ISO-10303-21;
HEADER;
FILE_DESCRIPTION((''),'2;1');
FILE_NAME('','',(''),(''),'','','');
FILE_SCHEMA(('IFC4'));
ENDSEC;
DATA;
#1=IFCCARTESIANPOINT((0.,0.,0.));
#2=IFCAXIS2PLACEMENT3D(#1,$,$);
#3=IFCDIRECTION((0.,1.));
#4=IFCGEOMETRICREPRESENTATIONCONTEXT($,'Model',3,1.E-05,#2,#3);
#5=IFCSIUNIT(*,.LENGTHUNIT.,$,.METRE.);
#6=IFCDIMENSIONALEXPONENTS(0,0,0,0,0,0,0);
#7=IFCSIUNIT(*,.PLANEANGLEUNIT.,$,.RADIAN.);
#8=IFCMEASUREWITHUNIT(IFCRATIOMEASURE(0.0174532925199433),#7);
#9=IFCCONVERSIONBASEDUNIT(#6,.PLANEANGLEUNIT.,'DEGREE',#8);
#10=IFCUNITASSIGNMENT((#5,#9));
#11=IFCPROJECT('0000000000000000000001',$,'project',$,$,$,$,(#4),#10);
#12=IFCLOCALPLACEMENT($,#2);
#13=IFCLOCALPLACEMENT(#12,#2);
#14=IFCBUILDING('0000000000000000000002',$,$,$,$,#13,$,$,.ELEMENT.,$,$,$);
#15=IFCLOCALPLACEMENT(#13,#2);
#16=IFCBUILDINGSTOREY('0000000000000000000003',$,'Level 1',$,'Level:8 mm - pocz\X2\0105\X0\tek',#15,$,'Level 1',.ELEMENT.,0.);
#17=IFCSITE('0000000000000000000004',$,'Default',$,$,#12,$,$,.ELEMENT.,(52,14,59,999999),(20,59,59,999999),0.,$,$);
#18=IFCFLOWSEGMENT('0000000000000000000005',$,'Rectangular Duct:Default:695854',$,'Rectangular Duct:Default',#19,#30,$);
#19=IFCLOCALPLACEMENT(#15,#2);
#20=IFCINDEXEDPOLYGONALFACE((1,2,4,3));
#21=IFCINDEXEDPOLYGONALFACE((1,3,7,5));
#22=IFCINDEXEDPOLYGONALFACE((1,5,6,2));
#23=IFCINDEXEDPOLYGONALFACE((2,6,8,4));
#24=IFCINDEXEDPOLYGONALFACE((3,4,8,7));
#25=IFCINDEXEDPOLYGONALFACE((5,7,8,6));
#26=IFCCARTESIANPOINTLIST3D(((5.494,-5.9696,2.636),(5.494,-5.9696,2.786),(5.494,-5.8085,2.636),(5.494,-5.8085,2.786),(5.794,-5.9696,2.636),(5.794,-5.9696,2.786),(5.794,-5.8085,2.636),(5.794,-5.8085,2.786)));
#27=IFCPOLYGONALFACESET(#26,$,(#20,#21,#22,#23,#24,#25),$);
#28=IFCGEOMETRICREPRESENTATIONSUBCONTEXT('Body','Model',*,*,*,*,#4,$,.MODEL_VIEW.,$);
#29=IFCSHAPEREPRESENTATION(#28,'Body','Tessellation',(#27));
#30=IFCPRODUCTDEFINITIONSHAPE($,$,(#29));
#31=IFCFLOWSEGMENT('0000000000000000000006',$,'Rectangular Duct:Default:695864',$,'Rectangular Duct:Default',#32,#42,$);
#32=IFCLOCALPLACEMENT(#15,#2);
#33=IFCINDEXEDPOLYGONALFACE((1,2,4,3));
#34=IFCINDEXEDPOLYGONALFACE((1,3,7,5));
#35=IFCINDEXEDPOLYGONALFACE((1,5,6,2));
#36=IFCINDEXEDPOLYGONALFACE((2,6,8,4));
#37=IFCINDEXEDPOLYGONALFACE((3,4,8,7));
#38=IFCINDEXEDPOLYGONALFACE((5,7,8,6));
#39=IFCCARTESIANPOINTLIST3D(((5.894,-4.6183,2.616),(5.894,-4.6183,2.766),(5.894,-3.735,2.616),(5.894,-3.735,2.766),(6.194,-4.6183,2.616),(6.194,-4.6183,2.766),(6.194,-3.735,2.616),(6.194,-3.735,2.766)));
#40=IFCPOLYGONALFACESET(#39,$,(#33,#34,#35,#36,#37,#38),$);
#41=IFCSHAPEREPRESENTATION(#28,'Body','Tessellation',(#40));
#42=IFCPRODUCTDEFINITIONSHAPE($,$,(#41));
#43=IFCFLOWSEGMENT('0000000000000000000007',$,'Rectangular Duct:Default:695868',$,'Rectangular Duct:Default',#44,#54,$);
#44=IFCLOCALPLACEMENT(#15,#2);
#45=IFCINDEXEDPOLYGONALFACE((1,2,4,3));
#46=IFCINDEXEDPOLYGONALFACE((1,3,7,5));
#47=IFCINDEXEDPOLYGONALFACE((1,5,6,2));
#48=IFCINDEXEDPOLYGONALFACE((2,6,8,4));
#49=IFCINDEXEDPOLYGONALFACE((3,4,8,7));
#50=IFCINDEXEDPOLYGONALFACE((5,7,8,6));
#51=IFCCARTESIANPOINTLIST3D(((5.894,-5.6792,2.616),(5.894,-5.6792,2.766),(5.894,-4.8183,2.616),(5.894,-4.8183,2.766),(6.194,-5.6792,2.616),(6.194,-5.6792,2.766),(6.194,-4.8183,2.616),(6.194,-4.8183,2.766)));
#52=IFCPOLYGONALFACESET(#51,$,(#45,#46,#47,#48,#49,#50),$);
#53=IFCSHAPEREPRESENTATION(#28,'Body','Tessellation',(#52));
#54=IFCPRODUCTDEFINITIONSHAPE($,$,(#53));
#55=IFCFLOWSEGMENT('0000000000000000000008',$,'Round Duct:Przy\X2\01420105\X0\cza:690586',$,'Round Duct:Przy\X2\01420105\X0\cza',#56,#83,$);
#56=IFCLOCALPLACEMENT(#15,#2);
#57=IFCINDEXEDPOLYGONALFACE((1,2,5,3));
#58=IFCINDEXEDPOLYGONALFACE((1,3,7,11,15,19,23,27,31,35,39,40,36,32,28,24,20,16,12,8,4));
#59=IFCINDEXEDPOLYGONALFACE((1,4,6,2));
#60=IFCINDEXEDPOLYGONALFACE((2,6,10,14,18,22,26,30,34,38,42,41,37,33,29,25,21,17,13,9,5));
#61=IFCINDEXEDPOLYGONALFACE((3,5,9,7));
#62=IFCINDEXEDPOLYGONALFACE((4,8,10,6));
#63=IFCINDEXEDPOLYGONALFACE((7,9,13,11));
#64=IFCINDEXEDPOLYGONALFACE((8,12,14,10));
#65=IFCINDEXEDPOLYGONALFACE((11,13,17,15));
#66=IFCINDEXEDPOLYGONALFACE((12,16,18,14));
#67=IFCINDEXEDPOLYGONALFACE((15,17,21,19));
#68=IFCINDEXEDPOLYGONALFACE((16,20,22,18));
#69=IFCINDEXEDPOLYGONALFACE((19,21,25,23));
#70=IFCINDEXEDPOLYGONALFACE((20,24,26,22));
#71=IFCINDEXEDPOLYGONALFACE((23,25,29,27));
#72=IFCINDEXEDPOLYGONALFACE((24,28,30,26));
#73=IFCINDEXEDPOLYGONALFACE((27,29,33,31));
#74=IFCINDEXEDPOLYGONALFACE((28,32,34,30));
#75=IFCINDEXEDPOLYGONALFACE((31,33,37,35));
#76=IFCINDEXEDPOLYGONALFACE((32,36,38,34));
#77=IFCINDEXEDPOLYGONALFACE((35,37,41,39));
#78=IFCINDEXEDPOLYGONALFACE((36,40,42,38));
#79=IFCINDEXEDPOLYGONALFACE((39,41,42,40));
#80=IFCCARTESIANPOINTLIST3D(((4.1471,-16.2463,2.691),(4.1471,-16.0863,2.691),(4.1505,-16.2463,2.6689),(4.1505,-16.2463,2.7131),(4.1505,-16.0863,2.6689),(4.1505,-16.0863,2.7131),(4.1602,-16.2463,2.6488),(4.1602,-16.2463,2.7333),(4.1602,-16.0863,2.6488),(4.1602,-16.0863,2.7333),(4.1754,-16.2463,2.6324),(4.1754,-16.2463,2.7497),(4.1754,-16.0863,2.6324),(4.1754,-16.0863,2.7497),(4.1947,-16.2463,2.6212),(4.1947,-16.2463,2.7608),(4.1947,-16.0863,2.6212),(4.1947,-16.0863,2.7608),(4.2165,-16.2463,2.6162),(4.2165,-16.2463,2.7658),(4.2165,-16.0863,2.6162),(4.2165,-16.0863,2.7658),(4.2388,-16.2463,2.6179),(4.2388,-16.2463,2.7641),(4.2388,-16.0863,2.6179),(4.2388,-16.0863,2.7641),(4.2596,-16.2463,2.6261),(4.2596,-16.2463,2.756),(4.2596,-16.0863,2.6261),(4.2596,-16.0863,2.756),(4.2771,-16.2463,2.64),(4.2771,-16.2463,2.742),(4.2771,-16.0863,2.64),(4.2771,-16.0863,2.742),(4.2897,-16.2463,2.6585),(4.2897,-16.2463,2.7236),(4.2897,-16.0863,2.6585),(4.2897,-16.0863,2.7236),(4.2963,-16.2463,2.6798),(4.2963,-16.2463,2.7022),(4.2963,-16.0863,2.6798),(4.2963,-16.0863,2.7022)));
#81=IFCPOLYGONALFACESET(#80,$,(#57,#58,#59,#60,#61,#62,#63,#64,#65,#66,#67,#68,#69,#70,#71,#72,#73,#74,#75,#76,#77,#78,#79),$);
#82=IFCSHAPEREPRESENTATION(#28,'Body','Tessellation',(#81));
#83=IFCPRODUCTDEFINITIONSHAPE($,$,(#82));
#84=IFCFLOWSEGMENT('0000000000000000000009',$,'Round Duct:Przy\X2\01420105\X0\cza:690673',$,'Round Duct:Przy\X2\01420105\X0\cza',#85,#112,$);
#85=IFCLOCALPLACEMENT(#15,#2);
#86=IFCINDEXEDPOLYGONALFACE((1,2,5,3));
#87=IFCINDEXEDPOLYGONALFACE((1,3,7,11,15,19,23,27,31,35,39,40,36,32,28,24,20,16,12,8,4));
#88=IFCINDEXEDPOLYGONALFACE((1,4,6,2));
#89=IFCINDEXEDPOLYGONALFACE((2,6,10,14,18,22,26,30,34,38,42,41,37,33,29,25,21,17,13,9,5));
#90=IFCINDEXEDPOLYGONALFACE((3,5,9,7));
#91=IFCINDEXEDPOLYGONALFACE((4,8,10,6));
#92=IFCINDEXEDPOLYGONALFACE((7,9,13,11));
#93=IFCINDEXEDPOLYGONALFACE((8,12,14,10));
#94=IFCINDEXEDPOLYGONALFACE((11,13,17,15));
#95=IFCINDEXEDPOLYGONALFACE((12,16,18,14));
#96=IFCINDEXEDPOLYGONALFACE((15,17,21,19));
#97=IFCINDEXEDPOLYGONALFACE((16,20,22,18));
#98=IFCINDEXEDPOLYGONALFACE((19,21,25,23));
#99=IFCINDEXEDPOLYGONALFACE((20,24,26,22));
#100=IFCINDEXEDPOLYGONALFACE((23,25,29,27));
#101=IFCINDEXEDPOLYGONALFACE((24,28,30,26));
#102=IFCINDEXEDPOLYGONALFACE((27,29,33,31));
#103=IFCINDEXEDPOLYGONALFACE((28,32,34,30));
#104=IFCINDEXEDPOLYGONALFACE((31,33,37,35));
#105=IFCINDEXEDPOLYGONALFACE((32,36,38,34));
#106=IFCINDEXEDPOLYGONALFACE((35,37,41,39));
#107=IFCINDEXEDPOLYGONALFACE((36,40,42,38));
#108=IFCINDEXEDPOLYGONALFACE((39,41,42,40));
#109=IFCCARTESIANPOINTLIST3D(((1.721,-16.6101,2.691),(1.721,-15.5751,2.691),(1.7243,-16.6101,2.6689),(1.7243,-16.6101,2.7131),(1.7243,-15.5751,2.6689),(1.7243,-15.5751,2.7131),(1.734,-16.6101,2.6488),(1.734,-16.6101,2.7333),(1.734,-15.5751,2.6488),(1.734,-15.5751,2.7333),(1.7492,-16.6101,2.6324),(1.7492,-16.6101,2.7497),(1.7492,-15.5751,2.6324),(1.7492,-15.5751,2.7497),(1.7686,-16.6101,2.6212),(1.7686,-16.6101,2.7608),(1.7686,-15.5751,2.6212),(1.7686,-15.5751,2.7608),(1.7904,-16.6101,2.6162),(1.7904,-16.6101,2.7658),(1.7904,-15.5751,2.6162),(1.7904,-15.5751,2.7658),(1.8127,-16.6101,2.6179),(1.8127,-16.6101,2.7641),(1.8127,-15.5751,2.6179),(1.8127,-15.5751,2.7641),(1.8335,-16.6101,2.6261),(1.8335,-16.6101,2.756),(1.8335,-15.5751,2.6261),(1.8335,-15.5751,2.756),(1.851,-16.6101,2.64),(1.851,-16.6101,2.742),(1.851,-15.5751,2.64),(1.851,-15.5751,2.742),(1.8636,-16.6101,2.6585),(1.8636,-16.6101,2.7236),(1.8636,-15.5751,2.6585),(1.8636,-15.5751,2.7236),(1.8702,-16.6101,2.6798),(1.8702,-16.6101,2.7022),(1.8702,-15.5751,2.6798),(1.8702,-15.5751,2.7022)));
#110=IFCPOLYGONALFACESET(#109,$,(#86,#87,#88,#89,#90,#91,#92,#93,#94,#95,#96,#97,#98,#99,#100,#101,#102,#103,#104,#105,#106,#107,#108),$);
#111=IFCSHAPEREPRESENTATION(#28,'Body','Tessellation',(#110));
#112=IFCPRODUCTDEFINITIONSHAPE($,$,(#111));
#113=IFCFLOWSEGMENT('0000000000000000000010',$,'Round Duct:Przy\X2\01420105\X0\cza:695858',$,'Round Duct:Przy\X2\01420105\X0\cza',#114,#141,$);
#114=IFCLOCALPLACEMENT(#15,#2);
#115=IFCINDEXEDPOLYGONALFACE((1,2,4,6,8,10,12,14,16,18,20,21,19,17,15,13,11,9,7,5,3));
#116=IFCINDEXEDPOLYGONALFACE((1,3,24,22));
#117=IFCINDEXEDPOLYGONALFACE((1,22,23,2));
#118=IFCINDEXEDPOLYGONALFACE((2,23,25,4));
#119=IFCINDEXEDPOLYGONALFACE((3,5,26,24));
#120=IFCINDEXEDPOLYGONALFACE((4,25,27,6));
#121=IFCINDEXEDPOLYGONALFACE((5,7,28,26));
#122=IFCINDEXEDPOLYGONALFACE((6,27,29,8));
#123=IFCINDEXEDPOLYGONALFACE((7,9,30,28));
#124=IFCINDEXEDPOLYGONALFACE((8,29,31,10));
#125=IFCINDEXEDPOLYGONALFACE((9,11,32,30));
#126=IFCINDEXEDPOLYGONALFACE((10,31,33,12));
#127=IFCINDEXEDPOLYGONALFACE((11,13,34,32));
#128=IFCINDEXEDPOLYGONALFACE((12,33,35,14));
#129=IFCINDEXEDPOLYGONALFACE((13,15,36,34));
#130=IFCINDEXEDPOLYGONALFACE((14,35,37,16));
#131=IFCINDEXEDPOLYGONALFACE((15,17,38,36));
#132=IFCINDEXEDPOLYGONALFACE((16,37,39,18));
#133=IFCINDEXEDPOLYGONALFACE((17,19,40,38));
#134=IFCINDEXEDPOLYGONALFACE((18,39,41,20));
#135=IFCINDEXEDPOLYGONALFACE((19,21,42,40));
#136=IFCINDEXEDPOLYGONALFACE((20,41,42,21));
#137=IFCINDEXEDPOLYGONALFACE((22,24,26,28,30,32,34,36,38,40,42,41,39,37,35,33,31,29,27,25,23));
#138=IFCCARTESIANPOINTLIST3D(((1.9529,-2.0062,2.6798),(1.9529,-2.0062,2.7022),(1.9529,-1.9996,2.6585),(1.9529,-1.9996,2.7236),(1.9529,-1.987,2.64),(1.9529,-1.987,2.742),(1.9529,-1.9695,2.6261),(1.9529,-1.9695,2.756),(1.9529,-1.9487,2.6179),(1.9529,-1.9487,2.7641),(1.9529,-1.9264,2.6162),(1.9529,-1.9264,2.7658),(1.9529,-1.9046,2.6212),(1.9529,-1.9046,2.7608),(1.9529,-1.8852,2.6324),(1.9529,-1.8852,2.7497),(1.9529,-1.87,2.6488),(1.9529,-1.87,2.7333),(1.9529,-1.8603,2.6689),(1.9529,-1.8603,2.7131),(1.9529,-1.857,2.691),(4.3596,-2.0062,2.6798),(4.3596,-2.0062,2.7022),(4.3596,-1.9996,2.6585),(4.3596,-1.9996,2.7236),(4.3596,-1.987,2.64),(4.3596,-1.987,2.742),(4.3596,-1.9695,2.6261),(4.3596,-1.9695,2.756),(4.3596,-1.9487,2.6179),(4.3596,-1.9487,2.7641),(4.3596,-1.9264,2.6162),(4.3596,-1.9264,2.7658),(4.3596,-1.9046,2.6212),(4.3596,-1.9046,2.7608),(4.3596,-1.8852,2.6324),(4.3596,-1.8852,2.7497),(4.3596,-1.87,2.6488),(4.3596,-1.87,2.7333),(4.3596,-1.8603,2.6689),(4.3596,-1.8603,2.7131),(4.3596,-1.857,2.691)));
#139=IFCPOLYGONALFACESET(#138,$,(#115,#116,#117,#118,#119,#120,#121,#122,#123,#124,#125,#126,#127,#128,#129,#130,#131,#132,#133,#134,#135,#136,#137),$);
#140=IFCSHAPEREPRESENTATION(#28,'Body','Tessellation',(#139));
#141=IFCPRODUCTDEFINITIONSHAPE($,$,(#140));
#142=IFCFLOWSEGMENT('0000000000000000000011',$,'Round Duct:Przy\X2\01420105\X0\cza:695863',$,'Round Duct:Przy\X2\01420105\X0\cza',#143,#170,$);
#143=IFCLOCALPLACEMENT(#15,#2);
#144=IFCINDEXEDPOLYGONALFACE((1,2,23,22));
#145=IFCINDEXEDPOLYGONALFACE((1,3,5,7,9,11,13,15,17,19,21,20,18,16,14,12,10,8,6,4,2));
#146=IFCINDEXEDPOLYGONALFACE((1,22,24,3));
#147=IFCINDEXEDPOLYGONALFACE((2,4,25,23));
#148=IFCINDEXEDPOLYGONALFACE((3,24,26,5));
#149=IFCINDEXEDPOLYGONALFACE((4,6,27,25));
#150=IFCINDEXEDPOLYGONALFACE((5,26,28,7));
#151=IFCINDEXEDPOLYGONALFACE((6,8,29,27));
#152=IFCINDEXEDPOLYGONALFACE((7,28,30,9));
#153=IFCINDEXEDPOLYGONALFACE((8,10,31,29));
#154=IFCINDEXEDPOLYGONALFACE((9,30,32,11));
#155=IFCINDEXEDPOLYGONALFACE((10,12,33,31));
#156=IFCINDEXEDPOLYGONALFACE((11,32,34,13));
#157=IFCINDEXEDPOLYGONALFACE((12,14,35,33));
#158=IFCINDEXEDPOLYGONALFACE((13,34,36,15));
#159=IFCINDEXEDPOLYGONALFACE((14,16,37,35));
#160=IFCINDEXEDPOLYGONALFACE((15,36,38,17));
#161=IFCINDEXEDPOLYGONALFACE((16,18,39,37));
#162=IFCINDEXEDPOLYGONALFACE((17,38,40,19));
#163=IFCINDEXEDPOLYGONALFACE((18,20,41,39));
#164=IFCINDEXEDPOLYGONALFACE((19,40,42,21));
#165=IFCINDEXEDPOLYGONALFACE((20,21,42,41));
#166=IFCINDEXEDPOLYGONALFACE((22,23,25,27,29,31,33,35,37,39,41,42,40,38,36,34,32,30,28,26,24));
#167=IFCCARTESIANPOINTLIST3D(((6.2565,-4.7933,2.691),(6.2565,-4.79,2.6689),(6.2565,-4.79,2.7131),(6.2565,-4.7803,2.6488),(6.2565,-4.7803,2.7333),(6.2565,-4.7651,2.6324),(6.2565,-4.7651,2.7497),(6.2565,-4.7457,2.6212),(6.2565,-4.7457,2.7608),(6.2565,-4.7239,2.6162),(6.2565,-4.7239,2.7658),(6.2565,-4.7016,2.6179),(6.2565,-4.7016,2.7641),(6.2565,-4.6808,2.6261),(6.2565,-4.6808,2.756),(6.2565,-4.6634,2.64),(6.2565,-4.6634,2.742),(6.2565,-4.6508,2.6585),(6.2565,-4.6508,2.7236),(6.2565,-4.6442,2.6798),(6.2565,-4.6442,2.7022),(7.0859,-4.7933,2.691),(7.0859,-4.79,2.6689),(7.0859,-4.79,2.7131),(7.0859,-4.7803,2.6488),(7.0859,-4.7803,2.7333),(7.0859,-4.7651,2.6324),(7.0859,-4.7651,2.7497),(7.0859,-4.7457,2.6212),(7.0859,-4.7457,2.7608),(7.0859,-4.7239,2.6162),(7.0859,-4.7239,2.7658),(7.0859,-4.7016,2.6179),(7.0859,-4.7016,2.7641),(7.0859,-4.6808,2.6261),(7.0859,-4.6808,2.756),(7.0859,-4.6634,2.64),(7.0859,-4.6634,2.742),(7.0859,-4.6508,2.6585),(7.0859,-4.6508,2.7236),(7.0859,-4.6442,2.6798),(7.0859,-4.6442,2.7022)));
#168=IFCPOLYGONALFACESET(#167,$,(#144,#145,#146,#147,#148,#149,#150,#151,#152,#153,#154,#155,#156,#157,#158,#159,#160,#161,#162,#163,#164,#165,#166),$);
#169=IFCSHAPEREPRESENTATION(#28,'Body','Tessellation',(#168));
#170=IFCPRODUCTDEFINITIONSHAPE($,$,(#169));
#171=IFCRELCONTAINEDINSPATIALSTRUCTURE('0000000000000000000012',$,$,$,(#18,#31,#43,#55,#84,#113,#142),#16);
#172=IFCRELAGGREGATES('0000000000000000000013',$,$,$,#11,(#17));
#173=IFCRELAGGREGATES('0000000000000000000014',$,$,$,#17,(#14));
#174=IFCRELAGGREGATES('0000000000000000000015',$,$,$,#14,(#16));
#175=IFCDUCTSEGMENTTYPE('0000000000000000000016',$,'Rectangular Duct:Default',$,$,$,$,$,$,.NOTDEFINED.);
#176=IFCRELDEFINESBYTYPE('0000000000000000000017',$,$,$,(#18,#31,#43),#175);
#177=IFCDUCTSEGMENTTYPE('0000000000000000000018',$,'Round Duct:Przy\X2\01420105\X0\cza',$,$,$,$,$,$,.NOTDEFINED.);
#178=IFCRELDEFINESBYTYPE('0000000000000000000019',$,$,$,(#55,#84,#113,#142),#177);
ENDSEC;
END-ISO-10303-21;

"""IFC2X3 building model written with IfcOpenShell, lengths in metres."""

from ifc_helpers import new_model, entity, si_unit, converted_unit, direction, frame, frame_2d, origin, place, context, subcontext, project, spatial, rectangle, circle, extrude, type_object, element, save


model = new_model("IFC2X3")

# Units and contexts
model_context = context("Model", 3, precision=1e-05, world=origin(), true_north=direction((0.0, 1.0)))
body_context = subcontext(model_context, "Body", "Model", "MODEL_VIEW")
ifc_project = project(units=[si_unit("LENGTHUNIT", "METRE"), converted_unit("PLANEANGLEUNIT", "DEGREE", entity("IfcRatioMeasure", 0.0174532925199433), si_unit("PLANEANGLEUNIT", "RADIAN"), dimensions=[0, 0, 0, 0, 0, 0, 0])], contexts=[model_context])

# Site, building, storey
site_placement = place(None, origin())
site = spatial("IfcSite", under=ifc_project, at=site_placement, Name="Default", CompositionType="ELEMENT", RefLatitude=(52, 14, 59, 999999), RefLongitude=(20, 59, 59, 999999), RefElevation=0.0)
building_placement = place(site_placement, origin())
building = spatial("IfcBuilding", under=site, at=building_placement, CompositionType="ELEMENT")
storey_placement = place(building_placement, origin())
storey = spatial("IfcBuildingStorey", under=building, at=storey_placement, Name="Level 1", ObjectType="Level:8 mm - początek", LongName="Level 1", CompositionType="ELEMENT", Elevation=0.0)

# Flow segments
duct_segment_type_1 = type_object("IfcDuctSegmentType", Name="Rectangular Duct:Default", PredefinedType="NOTDEFINED")
flow_segment_1_placement = place(storey_placement, origin())
element("IfcFlowSegment", 1, at=flow_segment_1_placement, inside=storey, type_object=duct_segment_type_1, Name="Rectangular Duct:Default:695854", ObjectType="Rectangular Duct:Default", context=body_context, shape_type="SweptSolid", body=[
    extrude(rectangle(XDim=0.1611, YDim=0.3, at=frame_2d((0.0, 0.0), x_axis=(1.0, 0.0))), frame((5.644, -5.889, 2.636), z_axis=(0.0, 0.0, 1.0), x_axis=(0.0, 1.0, 0.0)), (0.0, 0.0, 1.0), 0.15),
])
flow_segment_2_placement = place(storey_placement, origin())
element("IfcFlowSegment", 2, at=flow_segment_2_placement, inside=storey, type_object=duct_segment_type_1, Name="Rectangular Duct:Default:695864", ObjectType="Rectangular Duct:Default", context=body_context, shape_type="SweptSolid", body=[
    extrude(rectangle(XDim=0.8833, YDim=0.3, at=frame_2d((0.0, 0.0), x_axis=(1.0, 0.0))), frame((6.044, -4.1767, 2.616), z_axis=(0.0, 0.0, 1.0), x_axis=(0.0, 1.0, 0.0)), (0.0, 0.0, 1.0), 0.15),
])
flow_segment_3_placement = place(storey_placement, origin())
element("IfcFlowSegment", 3, at=flow_segment_3_placement, inside=storey, type_object=duct_segment_type_1, Name="Rectangular Duct:Default:695868", ObjectType="Rectangular Duct:Default", context=body_context, shape_type="SweptSolid", body=[
    extrude(rectangle(XDim=0.8609, YDim=0.3, at=frame_2d((0.0, 0.0), x_axis=(1.0, 0.0))), frame((6.044, -5.2488, 2.616), z_axis=(0.0, 0.0, 1.0), x_axis=(0.0, 1.0, 0.0)), (0.0, 0.0, 1.0), 0.15),
])
duct_segment_type_2 = type_object("IfcDuctSegmentType", Name="Round Duct:Przyłącza", PredefinedType="NOTDEFINED")
flow_segment_4_placement = place(storey_placement, origin())
element("IfcFlowSegment", 4, at=flow_segment_4_placement, inside=storey, type_object=duct_segment_type_2, Name="Round Duct:Przyłącza:690586", ObjectType="Round Duct:Przyłącza", context=body_context, shape_type="SweptSolid", body=[
    extrude(circle(Radius=0.075, at=frame_2d((0.0, 0.0), x_axis=(1.0, 0.0))), frame((4.2221, -16.2463, 2.691), z_axis=(0.0, 1.0, 0.0), x_axis=(-1.0, 0.0, 0.0)), (0.0, 0.0, 1.0), 0.16),
])
flow_segment_5_placement = place(storey_placement, origin())
element("IfcFlowSegment", 5, at=flow_segment_5_placement, inside=storey, type_object=duct_segment_type_2, Name="Round Duct:Przyłącza:690673", ObjectType="Round Duct:Przyłącza", context=body_context, shape_type="SweptSolid", body=[
    extrude(circle(Radius=0.075, at=frame_2d((0.0, 0.0), x_axis=(1.0, 0.0))), frame((1.796, -16.6101, 2.691), z_axis=(0.0, 1.0, 0.0), x_axis=(-1.0, 0.0, 0.0)), (0.0, 0.0, 1.0), 1.035),
])
flow_segment_6_placement = place(storey_placement, origin())
element("IfcFlowSegment", 6, at=flow_segment_6_placement, inside=storey, type_object=duct_segment_type_2, Name="Round Duct:Przyłącza:695858", ObjectType="Round Duct:Przyłącza", context=body_context, shape_type="SweptSolid", body=[
    extrude(circle(Radius=0.075, at=frame_2d((0.0, 0.0), x_axis=(1.0, 0.0))), frame((1.9529, -1.932, 2.691), z_axis=(1.0, 0.0, 0.0), x_axis=(0.0, 1.0, 0.0)), (0.0, 0.0, 1.0), 2.4067),
])
flow_segment_7_placement = place(storey_placement, origin())
element("IfcFlowSegment", 7, at=flow_segment_7_placement, inside=storey, type_object=duct_segment_type_2, Name="Round Duct:Przyłącza:695863", ObjectType="Round Duct:Przyłącza", context=body_context, shape_type="SweptSolid", body=[
    extrude(circle(Radius=0.075, at=frame_2d((0.0, 0.0), x_axis=(1.0, 0.0))), frame((6.2565, -4.7183, 2.691), z_axis=(1.0, 0.0, 0.0), x_axis=(0.0, -1.0, 0.0)), (0.0, 0.0, 1.0), 0.8294),
])

save(model, "model.ifc")
